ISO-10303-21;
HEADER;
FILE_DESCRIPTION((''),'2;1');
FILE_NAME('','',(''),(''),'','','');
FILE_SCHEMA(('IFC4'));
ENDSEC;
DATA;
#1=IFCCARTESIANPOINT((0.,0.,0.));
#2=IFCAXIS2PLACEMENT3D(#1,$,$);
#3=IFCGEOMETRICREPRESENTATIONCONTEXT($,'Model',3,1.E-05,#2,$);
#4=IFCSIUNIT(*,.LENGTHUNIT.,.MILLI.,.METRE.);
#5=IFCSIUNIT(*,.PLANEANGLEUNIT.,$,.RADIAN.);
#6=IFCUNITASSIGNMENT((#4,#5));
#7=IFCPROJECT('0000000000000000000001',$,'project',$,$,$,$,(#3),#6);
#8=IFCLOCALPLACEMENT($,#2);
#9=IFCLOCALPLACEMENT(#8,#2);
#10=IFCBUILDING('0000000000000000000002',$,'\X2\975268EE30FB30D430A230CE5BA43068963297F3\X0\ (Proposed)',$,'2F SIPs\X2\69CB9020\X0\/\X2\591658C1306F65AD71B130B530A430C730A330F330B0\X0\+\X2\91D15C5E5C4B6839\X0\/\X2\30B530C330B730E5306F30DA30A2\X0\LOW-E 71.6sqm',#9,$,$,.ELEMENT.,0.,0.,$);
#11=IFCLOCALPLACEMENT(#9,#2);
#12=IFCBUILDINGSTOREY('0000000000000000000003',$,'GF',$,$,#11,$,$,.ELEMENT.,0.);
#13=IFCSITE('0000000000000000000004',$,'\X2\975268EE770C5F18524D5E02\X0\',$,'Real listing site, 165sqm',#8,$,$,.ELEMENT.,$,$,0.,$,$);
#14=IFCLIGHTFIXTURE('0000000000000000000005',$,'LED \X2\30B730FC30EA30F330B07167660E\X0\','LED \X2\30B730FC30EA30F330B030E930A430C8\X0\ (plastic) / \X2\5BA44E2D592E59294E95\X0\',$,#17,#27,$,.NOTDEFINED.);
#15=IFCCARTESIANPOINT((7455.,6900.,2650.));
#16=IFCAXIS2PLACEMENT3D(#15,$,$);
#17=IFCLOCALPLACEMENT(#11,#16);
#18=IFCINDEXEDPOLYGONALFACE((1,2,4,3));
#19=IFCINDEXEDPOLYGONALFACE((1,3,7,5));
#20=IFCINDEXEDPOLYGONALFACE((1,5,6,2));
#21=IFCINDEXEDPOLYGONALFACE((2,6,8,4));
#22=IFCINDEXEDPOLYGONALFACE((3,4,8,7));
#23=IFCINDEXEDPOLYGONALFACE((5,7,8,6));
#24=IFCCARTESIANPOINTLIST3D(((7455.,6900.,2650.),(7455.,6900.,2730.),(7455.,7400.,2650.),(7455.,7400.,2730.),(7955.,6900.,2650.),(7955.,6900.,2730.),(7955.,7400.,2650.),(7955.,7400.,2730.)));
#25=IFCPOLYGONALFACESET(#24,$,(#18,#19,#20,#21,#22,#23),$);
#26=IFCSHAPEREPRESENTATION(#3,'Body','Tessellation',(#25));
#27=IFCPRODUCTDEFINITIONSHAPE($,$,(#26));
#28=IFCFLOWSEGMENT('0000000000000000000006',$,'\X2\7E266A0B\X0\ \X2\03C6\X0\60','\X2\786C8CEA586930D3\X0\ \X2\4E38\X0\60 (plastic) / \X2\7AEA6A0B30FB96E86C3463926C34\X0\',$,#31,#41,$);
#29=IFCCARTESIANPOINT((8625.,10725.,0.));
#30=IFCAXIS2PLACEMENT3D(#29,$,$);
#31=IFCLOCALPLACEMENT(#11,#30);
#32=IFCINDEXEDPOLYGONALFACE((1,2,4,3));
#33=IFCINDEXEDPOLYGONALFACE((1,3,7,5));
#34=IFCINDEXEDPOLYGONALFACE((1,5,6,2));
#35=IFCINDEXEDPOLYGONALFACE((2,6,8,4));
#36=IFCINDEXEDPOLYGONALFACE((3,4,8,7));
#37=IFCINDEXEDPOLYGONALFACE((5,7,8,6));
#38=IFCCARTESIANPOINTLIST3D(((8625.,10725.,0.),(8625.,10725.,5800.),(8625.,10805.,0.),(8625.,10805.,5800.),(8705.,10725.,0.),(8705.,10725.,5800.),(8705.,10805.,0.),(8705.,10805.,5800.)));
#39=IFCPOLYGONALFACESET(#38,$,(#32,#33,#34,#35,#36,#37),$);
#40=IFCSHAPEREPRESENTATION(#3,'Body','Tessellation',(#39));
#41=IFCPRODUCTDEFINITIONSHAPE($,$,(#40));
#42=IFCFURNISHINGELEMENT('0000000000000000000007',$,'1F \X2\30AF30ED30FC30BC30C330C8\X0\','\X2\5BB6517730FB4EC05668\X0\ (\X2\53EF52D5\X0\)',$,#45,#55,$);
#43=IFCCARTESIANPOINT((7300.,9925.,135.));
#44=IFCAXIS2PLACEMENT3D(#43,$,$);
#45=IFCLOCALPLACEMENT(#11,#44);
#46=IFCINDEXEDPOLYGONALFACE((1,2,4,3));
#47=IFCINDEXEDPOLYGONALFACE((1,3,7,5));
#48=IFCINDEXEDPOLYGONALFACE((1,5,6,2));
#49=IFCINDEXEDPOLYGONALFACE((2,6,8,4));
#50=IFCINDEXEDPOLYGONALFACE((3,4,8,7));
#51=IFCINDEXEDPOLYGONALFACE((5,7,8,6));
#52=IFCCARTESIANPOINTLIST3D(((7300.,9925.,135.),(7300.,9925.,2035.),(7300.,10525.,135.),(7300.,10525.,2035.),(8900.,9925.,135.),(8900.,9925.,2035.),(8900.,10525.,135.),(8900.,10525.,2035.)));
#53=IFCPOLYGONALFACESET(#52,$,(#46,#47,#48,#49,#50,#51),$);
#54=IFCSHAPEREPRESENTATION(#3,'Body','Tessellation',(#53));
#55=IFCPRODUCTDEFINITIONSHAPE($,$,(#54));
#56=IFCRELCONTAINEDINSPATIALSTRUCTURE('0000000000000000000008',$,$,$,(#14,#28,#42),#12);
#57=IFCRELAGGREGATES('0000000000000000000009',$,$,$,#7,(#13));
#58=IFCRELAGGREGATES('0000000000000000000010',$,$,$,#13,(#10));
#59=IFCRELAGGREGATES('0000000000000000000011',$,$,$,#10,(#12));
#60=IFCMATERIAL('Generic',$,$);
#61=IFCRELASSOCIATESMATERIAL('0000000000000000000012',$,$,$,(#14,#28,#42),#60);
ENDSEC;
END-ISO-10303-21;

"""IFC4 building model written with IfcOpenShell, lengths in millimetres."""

from ifc_helpers import new_model, si_unit, frame, frame_2d, origin, place, context, project, spatial, rectangle, extrude, material, element, save


model = new_model("IFC4")

# Units and contexts
model_context = context("Model", 3, precision=1e-05, world=origin())
ifc_project = project(units=[si_unit("LENGTHUNIT", "METRE", prefix="MILLI"), si_unit("PLANEANGLEUNIT", "RADIAN")], contexts=[model_context])

# Site, building, storey
site_placement = place(None, origin())
site = spatial("IfcSite", under=ifc_project, at=site_placement, Name="青森県弘前市", ObjectType="Real listing site, 165sqm", CompositionType="ELEMENT", RefElevation=0.0)
building_placement = place(site_placement, origin())
building = spatial("IfcBuilding", under=site, at=building_placement, Name="青森・ピアノ室と防音 (Proposed)", ObjectType="2F SIPs構造/外壁は断熱サイディング+金属屋根/サッシュはペアLOW-E 71.6sqm", CompositionType="ELEMENT", ElevationOfRefHeight=0.0, ElevationOfTerrain=0.0)
storey_placement = place(building_placement, origin())
storey = spatial("IfcBuildingStorey", under=building, at=storey_placement, Name="GF", CompositionType="ELEMENT", Elevation=0.0)

# Shared definitions
ifc_material_1 = material(Name="Generic")

# Light fixture
light_fixture_placement = place(storey_placement, frame((7455.0, 6900.0, 2650.0)))
element("IfcLightFixture", 1, at=light_fixture_placement, inside=storey, material=ifc_material_1, Name="LED シーリング照明", Description="LED シーリングライト (plastic) / 室中央天井", PredefinedType="NOTDEFINED", context=model_context, shape_type="SweptSolid", body=[
    extrude(rectangle(XDim=500.0, YDim=500.0, at=frame_2d((250.0, 250.0))), frame((7455.0, 6900.0, 2650.0)), (0.0, 0.0, 1.0), 80.0),
])

# Flow segment
flow_segment_placement = place(storey_placement, frame((8625.0, 10725.0, 0.0)))
element("IfcFlowSegment", 2, at=flow_segment_placement, inside=storey, material=ifc_material_1, Name="縦樋 φ60", Description="硬質塩ビ 丸60 (plastic) / 竪樋・雨水排水", context=model_context, shape_type="SweptSolid", body=[
    extrude(rectangle(XDim=80.0, YDim=80.0, at=frame_2d((40.0, 40.0))), frame((8625.0, 10725.0, 0.0)), (0.0, 0.0, 1.0), 5800.0),
])

# Furnishing element
furnishing_placement = place(storey_placement, frame((7300.0, 9925.0, 135.0)))
element("IfcFurnishingElement", 3, at=furnishing_placement, inside=storey, material=ifc_material_1, Name="1F クローゼット", Description="家具・什器 (可動)", context=model_context, shape_type="SweptSolid", body=[
    extrude(rectangle(XDim=1600.0, YDim=600.0, at=frame_2d((800.0, 300.0))), frame((7300.0, 9925.0, 135.0)), (0.0, 0.0, 1.0), 1900.0),
])

save(model, "model.ifc")
